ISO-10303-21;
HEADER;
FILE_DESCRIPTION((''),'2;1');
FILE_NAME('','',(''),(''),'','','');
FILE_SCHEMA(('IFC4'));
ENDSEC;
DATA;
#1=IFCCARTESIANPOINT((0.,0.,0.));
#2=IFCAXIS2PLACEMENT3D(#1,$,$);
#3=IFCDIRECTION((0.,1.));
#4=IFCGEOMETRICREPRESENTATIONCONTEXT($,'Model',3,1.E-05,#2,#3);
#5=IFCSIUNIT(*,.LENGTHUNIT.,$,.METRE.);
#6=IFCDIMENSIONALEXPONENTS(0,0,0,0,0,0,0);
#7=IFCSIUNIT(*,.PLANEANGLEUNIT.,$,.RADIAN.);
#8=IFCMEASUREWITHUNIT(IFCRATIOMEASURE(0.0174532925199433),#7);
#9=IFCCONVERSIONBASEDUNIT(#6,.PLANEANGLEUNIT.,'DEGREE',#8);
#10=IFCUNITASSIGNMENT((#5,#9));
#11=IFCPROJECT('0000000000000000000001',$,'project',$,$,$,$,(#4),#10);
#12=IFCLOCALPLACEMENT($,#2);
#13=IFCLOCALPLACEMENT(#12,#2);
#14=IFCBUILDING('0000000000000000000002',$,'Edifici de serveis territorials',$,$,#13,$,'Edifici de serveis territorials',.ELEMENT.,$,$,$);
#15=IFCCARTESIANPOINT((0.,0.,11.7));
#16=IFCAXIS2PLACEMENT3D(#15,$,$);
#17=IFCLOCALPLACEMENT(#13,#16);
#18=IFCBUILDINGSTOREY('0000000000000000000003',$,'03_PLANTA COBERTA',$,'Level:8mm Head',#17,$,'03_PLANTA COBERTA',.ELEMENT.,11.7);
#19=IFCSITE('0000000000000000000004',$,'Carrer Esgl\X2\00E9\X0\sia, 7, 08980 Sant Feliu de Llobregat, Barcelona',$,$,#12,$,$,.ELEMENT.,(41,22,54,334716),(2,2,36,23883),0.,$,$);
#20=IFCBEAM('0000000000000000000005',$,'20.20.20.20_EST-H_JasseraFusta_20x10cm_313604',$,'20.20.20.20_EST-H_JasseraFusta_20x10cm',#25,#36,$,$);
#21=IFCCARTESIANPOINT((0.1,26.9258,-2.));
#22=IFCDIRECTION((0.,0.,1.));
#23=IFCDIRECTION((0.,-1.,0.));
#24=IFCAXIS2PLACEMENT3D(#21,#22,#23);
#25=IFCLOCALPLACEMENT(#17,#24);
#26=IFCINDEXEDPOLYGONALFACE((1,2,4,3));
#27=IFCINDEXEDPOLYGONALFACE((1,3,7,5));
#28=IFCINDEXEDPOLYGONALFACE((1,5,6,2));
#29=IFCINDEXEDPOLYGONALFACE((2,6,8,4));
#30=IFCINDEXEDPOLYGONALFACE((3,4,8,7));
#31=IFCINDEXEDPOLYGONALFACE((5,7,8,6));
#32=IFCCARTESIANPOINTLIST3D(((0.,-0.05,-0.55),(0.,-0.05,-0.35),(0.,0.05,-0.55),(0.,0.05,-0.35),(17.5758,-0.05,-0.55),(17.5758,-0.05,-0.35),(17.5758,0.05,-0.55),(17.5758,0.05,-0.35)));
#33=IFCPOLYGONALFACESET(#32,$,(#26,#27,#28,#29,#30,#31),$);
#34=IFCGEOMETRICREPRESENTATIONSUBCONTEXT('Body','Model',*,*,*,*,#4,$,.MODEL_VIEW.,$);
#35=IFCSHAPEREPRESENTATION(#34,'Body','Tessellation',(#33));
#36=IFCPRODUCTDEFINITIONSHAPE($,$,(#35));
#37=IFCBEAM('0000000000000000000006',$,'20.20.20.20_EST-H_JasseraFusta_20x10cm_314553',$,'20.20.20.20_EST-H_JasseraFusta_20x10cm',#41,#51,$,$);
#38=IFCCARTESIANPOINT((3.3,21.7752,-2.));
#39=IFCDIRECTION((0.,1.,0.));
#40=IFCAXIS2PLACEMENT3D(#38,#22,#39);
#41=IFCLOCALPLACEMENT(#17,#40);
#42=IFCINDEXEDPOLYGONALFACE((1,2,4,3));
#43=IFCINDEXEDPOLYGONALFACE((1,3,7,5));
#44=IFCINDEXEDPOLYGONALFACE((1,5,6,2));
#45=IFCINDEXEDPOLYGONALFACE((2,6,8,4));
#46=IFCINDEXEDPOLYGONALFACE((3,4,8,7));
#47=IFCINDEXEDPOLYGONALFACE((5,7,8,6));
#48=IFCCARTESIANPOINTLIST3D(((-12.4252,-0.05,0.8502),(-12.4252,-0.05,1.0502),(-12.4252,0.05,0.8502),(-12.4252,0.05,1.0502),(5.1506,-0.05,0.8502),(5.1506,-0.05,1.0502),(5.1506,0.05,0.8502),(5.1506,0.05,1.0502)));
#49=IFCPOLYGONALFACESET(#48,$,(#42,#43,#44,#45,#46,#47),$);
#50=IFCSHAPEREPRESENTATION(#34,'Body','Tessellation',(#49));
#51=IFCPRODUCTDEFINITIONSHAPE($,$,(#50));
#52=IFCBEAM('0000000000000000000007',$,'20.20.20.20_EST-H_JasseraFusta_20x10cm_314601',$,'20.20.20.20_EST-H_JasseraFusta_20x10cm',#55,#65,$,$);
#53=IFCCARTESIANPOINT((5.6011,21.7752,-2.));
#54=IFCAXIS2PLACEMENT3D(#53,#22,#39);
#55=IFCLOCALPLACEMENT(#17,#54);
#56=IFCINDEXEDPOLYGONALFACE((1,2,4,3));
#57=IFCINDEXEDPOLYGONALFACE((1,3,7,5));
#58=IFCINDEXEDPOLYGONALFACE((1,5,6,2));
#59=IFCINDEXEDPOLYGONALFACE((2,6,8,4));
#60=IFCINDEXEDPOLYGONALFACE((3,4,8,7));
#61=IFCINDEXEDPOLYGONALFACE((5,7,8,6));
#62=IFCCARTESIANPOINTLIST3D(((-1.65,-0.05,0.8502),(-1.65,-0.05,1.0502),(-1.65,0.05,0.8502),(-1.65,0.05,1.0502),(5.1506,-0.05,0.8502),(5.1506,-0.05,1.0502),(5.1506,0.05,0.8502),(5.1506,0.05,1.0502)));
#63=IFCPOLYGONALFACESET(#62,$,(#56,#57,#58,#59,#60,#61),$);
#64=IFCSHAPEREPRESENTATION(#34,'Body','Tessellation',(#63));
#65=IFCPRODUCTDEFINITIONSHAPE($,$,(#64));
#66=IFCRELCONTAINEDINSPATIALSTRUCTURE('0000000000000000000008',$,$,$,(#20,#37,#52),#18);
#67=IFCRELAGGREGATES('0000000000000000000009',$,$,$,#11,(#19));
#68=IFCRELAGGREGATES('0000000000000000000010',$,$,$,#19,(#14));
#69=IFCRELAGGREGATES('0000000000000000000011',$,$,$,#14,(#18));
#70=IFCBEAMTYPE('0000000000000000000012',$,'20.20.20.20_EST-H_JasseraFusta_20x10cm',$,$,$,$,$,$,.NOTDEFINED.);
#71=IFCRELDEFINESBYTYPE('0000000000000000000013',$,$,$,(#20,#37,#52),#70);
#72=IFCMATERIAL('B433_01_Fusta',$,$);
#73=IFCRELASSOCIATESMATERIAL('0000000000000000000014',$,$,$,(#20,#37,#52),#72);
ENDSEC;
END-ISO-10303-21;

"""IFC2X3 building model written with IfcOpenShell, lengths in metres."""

from ifc_helpers import new_model, entity, si_unit, converted_unit, direction, frame, frame_2d, origin, place, context, subcontext, project, spatial, rectangle, extrude, material, type_object, element, save


model = new_model("IFC2X3")

# Units and contexts
model_context = context("Model", 3, precision=1e-05, world=origin(), true_north=direction((0.0, 1.0)))
body_context = subcontext(model_context, "Body", "Model", "MODEL_VIEW")
ifc_project = project(units=[si_unit("LENGTHUNIT", "METRE"), converted_unit("PLANEANGLEUNIT", "DEGREE", entity("IfcRatioMeasure", 0.0174532925199433), si_unit("PLANEANGLEUNIT", "RADIAN"), dimensions=[0, 0, 0, 0, 0, 0, 0])], contexts=[model_context])

# Site, building, storey
site_placement = place(None, origin())
site = spatial("IfcSite", under=ifc_project, at=site_placement, Name="Carrer Església, 7, 08980 Sant Feliu de Llobregat, Barcelona", CompositionType="ELEMENT", RefLatitude=(41, 22, 54, 334716), RefLongitude=(2, 2, 36, 23883), RefElevation=0.0)
building_placement = place(site_placement, origin())
building = spatial("IfcBuilding", under=site, at=building_placement, Name="Edifici de serveis territorials", LongName="Edifici de serveis territorials", CompositionType="ELEMENT")
storey_placement = place(building_placement, frame((0.0, 0.0, 11.7)))
storey = spatial("IfcBuildingStorey", under=building, at=storey_placement, Name="03_PLANTA COBERTA", ObjectType="Level:8mm Head", LongName="03_PLANTA COBERTA", CompositionType="ELEMENT", Elevation=11.7)

# Beams
ifc_material_1 = material(Name="B433_01_Fusta")
beam_type = type_object("IfcBeamType", Name="20.20.20.20_EST-H_JasseraFusta_20x10cm", PredefinedType="NOTDEFINED")
beam_1_placement = place(storey_placement, frame((0.1, 26.9258, -2.0), z_axis=(0.0, 0.0, 1.0), x_axis=(0.0, -1.0, 0.0)))
element("IfcBeam", 1, at=beam_1_placement, inside=storey, type_object=beam_type, material=ifc_material_1, Name="20.20.20.20_EST-H_JasseraFusta_20x10cm_313604", ObjectType="20.20.20.20_EST-H_JasseraFusta_20x10cm", context=body_context, shape_type="SweptSolid", body=[
    extrude(rectangle(XDim=0.2, YDim=0.1, at=frame_2d((0.0, 0.0), x_axis=(1.0, 0.0))), frame((0.0, 0.0, -0.45), z_axis=(1.0, 0.0, 0.0), x_axis=(0.0, 0.0, -1.0)), (0.0, 0.0, 1.0), 17.5758),
])
beam_2_placement = place(storey_placement, frame((3.3, 21.7752, -2.0), z_axis=(0.0, 0.0, 1.0), x_axis=(0.0, 1.0, 0.0)))
element("IfcBeam", 2, at=beam_2_placement, inside=storey, type_object=beam_type, material=ifc_material_1, Name="20.20.20.20_EST-H_JasseraFusta_20x10cm_314553", ObjectType="20.20.20.20_EST-H_JasseraFusta_20x10cm", context=body_context, shape_type="SweptSolid", body=[
    extrude(rectangle(XDim=0.2, YDim=0.1, at=frame_2d((0.0, 0.0), x_axis=(1.0, 0.0))), frame((-12.4252, 0.0, 0.9502), z_axis=(1.0, 0.0, 0.0), x_axis=(0.0, 0.0, -1.0)), (0.0, 0.0, 1.0), 17.5758),
])
beam_3_placement = place(storey_placement, frame((5.6011, 21.7752, -2.0), z_axis=(0.0, 0.0, 1.0), x_axis=(0.0, 1.0, 0.0)))
element("IfcBeam", 3, at=beam_3_placement, inside=storey, type_object=beam_type, material=ifc_material_1, Name="20.20.20.20_EST-H_JasseraFusta_20x10cm_314601", ObjectType="20.20.20.20_EST-H_JasseraFusta_20x10cm", context=body_context, shape_type="SweptSolid", body=[
    extrude(rectangle(XDim=0.2, YDim=0.1, at=frame_2d((0.0, 0.0), x_axis=(1.0, 0.0))), frame((-1.65, 0.0, 0.9502), z_axis=(1.0, 0.0, 0.0), x_axis=(0.0, 0.0, -1.0)), (0.0, 0.0, 1.0), 6.8006),
])

save(model, "model.ifc")
